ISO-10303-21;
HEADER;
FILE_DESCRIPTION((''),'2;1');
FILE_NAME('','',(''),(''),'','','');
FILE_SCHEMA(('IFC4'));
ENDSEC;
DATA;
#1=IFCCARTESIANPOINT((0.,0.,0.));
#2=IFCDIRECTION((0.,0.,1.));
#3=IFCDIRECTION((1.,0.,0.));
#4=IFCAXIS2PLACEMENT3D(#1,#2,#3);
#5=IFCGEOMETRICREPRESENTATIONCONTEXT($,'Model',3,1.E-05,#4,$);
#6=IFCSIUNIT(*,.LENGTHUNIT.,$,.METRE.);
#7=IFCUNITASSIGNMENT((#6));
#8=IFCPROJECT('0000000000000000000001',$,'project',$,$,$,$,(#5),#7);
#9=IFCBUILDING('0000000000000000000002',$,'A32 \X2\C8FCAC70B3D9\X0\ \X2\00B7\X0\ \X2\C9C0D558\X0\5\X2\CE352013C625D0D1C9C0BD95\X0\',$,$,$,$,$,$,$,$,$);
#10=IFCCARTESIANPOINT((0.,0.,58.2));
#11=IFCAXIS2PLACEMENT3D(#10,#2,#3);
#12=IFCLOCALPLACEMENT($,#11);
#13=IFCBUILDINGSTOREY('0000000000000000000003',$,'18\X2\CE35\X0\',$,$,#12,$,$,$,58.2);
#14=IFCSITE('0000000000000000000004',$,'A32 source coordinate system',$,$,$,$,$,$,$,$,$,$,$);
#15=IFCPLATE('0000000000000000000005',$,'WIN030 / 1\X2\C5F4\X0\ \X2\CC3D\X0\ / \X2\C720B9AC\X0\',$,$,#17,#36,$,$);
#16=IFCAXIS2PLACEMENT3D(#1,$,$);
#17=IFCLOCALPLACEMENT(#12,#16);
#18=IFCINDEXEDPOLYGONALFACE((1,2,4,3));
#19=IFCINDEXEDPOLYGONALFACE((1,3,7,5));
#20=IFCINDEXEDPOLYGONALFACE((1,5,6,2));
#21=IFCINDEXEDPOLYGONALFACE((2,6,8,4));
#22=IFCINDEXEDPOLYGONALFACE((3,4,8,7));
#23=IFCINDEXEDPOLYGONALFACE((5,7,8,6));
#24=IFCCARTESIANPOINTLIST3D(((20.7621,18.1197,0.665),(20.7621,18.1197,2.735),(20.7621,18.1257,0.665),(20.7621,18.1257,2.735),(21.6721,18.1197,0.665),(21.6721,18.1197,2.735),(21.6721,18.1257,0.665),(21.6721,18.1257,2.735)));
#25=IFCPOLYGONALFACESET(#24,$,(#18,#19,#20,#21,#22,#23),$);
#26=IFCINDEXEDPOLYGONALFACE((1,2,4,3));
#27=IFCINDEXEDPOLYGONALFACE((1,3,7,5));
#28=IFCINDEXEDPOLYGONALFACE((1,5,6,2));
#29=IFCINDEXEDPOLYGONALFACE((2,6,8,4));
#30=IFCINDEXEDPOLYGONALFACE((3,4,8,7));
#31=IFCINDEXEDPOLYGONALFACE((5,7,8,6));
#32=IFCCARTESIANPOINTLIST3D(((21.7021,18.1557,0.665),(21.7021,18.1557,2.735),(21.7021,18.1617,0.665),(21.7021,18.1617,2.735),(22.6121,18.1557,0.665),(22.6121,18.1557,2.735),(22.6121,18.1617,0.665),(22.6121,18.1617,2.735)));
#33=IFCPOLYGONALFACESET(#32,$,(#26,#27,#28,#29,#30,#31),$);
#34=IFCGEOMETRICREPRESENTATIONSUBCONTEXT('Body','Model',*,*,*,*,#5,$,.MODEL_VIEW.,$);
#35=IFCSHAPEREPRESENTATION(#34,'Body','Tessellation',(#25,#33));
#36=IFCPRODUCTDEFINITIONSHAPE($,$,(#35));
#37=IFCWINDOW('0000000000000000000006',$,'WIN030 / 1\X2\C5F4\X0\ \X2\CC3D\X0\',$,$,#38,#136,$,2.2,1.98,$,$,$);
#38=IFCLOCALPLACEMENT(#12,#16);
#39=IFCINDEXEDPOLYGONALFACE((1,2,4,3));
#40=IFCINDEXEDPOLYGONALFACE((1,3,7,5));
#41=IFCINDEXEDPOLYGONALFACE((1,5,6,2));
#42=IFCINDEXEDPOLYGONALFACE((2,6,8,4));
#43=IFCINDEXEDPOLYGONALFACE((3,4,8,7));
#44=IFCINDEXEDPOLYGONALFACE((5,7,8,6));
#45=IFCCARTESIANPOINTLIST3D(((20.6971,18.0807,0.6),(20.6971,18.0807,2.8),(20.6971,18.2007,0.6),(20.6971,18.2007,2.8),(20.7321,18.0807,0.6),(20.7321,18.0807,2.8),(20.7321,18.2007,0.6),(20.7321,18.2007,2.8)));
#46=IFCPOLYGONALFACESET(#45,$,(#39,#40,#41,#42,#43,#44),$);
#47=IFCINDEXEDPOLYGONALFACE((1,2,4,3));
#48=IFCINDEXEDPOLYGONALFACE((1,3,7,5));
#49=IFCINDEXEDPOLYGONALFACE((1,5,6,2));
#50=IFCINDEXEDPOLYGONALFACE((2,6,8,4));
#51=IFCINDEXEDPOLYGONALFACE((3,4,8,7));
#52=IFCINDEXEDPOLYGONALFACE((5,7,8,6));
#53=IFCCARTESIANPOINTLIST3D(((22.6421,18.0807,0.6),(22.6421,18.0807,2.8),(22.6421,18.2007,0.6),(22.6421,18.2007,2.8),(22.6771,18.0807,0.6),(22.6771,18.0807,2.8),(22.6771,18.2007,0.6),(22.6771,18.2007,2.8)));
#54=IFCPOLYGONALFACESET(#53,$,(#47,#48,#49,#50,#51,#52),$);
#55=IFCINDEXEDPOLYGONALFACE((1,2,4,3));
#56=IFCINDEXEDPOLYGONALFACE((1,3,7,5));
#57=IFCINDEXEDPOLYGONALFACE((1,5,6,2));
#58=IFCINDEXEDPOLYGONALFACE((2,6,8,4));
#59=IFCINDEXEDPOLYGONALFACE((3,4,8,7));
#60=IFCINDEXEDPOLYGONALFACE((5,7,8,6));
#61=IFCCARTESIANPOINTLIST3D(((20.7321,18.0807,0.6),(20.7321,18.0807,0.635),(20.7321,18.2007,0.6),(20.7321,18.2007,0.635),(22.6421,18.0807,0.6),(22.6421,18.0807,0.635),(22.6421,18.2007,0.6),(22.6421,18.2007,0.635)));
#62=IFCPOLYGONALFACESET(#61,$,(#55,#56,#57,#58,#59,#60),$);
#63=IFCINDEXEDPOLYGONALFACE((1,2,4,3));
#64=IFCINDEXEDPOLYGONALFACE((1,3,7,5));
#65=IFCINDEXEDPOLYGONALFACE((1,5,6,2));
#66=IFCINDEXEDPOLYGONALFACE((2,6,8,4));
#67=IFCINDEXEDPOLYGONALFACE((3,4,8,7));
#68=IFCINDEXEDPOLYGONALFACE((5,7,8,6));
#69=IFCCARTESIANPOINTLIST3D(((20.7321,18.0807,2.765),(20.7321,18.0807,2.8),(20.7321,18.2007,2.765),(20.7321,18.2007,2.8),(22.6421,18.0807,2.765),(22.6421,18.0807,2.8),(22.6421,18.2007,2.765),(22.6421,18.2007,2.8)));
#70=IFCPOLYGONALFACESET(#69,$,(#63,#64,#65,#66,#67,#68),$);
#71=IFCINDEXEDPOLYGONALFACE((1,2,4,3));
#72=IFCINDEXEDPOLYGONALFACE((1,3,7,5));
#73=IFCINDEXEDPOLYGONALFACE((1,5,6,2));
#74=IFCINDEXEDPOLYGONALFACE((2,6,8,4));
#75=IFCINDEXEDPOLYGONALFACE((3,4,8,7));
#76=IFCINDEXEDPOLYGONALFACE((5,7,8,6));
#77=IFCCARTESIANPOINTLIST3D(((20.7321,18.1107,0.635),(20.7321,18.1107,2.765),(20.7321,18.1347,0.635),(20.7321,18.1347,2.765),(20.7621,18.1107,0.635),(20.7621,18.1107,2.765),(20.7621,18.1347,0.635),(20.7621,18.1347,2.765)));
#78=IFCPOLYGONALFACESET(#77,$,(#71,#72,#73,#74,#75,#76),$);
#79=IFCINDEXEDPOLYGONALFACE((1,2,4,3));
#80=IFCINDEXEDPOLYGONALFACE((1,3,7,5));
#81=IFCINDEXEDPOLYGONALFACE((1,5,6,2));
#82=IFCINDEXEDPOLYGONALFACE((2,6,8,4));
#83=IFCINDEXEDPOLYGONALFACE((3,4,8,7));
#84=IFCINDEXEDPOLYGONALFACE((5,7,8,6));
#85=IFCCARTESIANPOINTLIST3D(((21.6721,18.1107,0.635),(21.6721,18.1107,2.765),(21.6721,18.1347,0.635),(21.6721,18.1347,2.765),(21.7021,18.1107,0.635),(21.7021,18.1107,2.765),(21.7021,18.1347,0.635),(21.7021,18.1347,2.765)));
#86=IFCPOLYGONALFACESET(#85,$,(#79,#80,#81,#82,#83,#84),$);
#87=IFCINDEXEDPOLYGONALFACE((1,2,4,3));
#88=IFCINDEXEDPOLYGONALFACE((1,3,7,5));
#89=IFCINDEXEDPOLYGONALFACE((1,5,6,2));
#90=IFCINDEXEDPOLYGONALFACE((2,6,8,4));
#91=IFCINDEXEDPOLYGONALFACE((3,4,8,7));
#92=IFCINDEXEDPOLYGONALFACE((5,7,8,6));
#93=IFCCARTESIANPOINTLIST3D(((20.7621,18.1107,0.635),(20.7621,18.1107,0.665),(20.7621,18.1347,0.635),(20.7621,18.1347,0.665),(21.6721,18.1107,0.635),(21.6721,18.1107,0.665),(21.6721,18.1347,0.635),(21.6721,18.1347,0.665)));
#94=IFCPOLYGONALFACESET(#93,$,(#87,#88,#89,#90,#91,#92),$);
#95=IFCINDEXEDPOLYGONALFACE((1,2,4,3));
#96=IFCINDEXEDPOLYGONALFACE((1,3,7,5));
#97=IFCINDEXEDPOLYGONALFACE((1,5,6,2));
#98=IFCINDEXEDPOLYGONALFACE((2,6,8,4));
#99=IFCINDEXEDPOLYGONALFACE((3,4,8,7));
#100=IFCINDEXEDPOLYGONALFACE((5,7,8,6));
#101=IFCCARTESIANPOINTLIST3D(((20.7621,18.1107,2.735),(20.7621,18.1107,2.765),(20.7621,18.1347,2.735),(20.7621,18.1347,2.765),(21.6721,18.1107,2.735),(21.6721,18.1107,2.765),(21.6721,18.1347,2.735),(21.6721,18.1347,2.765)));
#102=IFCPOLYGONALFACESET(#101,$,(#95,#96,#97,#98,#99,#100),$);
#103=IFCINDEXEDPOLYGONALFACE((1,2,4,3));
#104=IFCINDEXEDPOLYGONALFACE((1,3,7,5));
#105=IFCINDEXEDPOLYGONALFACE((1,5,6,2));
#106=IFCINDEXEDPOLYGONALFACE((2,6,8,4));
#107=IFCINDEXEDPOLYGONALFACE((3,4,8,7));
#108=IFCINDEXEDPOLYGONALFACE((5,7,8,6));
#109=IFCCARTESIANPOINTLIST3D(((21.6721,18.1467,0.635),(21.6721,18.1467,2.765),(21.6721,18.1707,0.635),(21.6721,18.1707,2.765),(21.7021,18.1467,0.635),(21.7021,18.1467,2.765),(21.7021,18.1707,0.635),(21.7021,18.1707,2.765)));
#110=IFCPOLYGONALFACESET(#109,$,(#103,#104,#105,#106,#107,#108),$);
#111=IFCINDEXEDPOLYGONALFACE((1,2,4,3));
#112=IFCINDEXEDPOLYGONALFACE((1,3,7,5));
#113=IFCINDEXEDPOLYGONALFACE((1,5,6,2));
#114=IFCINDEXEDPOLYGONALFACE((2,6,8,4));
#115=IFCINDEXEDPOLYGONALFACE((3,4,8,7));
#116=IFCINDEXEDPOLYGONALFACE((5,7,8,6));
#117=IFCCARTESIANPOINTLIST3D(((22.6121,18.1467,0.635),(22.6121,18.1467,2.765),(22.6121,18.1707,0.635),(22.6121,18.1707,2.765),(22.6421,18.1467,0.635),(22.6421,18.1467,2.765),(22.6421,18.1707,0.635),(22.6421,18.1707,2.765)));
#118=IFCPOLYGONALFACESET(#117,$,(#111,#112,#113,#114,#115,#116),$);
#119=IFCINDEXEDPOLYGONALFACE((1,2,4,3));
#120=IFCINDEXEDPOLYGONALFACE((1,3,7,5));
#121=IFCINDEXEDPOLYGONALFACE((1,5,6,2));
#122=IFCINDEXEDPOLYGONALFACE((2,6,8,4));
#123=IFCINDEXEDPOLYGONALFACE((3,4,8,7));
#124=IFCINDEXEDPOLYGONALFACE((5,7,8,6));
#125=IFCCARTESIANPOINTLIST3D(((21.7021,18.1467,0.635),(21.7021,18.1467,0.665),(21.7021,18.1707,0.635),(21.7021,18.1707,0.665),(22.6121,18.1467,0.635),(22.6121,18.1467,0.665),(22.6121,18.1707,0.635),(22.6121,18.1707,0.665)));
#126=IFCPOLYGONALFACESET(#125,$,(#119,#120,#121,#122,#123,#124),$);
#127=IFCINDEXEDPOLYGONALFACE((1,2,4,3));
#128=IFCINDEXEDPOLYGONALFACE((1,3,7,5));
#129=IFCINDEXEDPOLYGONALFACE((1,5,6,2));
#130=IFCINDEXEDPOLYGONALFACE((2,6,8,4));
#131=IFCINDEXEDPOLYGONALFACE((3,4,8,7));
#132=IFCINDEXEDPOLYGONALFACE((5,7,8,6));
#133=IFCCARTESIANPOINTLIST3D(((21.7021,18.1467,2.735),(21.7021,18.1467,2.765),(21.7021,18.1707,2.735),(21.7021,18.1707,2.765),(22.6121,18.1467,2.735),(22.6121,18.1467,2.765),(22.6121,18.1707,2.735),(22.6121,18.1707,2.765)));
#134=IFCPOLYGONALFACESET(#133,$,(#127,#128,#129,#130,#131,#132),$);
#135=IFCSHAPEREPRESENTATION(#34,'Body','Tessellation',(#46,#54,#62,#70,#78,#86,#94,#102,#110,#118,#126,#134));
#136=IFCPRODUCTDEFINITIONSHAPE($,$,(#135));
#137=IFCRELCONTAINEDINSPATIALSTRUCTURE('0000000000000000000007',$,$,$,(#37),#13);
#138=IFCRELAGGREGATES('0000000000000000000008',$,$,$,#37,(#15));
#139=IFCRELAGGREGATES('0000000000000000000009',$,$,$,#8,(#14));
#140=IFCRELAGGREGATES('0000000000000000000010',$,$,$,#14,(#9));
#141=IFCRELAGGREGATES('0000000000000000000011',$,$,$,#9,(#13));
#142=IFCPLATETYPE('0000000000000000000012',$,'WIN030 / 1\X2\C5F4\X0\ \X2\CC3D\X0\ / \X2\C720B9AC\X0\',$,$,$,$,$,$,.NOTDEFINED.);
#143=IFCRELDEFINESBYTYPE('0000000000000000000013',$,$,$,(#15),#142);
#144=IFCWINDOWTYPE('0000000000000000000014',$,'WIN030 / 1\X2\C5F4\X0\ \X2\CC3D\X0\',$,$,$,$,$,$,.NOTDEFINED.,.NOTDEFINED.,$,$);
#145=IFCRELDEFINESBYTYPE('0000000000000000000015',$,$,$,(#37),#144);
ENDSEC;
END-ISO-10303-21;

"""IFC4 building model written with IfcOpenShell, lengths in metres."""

from ifc_helpers import new_model, si_unit, frame, origin, origin_with_axes, place, context, subcontext, project, spatial, polyline, outline, extrude, source, transform, mapped, type_object, type_shapes, element, aggregate, save


model = new_model("IFC4")

# Units and contexts
model_context = context("Model", 3, precision=1e-05, world=origin_with_axes())
body_context = subcontext(model_context, "Body", "Model", "MODEL_VIEW")
ifc_project = project(units=[si_unit("LENGTHUNIT", "METRE")], contexts=[model_context])

# Plate
storey_placement = place(None, frame((0.0, 0.0, 58.2), z_axis=(0.0, 0.0, 1.0), x_axis=(1.0, 0.0, 0.0)))
plate_type_1 = type_object("IfcPlateType", Name="WIN030 / 1열 창 / 유리", PredefinedType="NOTDEFINED")
shared_shape_1 = source(origin(), body_context, "Body", "SweptSolid", [
    extrude(outline(polyline([(20.7621, 18.1197), (20.7621, 18.1257), (21.6721, 18.1257), (21.6721, 18.1197), (20.7621, 18.1197)])), frame((0.0, 0.0, 0.665)), (0.0, 0.0, 1.0), 2.07),
    extrude(outline(polyline([(21.7021, 18.1557), (21.7021, 18.1617), (22.6121, 18.1617), (22.6121, 18.1557), (21.7021, 18.1557)])), frame((0.0, 0.0, 0.665)), (0.0, 0.0, 1.0), 2.07),
])
type_shapes(plate_type_1, [shared_shape_1])
window_1_placement = place(storey_placement, origin_with_axes())
plate_1_placement = place(window_1_placement, origin_with_axes())
plate_1 = element("IfcPlate", 1, at=plate_1_placement, type_object=plate_type_1, Name="WIN030 / 1열 창 / 유리", context=body_context, shape_type="MappedRepresentation", body=[
    mapped(shared_shape_1, transform((0.0, 0.0, 0.0), scale=1.0)),
])

# Site, building, storey
site = spatial("IfcSite", under=ifc_project, Name="A32 source coordinate system")
building = spatial("IfcBuilding", under=site, Name="A32 주거동 · 지하5층–옥탑지붕")
storey = spatial("IfcBuildingStorey", under=building, at=storey_placement, Name="18층", Elevation=58.2)

# Window
window_type_1 = type_object("IfcWindowType", Name="WIN030 / 1열 창", PartitioningType="NOTDEFINED", PredefinedType="NOTDEFINED")
shared_shape_2 = source(origin(), body_context, "Body", "SweptSolid", [
    extrude(outline(polyline([(20.6971, 18.0807), (20.6971, 18.2007), (20.7321, 18.2007), (20.7321, 18.0807), (20.6971, 18.0807)])), frame((0.0, 0.0, 0.6)), (0.0, 0.0, 1.0), 2.2),
    extrude(outline(polyline([(22.6421, 18.0807), (22.6421, 18.2007), (22.6771, 18.2007), (22.6771, 18.0807), (22.6421, 18.0807)])), frame((0.0, 0.0, 0.6)), (0.0, 0.0, 1.0), 2.2),
    extrude(outline(polyline([(20.7321, 18.0807), (20.7321, 18.2007), (22.6421, 18.2007), (22.6421, 18.0807), (20.7321, 18.0807)])), frame((0.0, 0.0, 0.6)), (0.0, 0.0, 1.0), 0.035),
    extrude(outline(polyline([(20.7321, 18.0807), (20.7321, 18.2007), (22.6421, 18.2007), (22.6421, 18.0807), (20.7321, 18.0807)])), frame((0.0, 0.0, 2.765)), (0.0, 0.0, 1.0), 0.035),
    extrude(outline(polyline([(20.7321, 18.1107), (20.7321, 18.1347), (20.7621, 18.1347), (20.7621, 18.1107), (20.7321, 18.1107)])), frame((0.0, 0.0, 0.635)), (0.0, 0.0, 1.0), 2.13),
    extrude(outline(polyline([(21.6721, 18.1107), (21.6721, 18.1347), (21.7021, 18.1347), (21.7021, 18.1107), (21.6721, 18.1107)])), frame((0.0, 0.0, 0.635)), (0.0, 0.0, 1.0), 2.13),
    extrude(outline(polyline([(20.7621, 18.1107), (20.7621, 18.1347), (21.6721, 18.1347), (21.6721, 18.1107), (20.7621, 18.1107)])), frame((0.0, 0.0, 0.635)), (0.0, 0.0, 1.0), 0.03),
    extrude(outline(polyline([(20.7621, 18.1107), (20.7621, 18.1347), (21.6721, 18.1347), (21.6721, 18.1107), (20.7621, 18.1107)])), frame((0.0, 0.0, 2.735)), (0.0, 0.0, 1.0), 0.03),
    extrude(outline(polyline([(21.6721, 18.1467), (21.6721, 18.1707), (21.7021, 18.1707), (21.7021, 18.1467), (21.6721, 18.1467)])), frame((0.0, 0.0, 0.635)), (0.0, 0.0, 1.0), 2.13),
    extrude(outline(polyline([(22.6121, 18.1467), (22.6121, 18.1707), (22.6421, 18.1707), (22.6421, 18.1467), (22.6121, 18.1467)])), frame((0.0, 0.0, 0.635)), (0.0, 0.0, 1.0), 2.13),
    extrude(outline(polyline([(21.7021, 18.1467), (21.7021, 18.1707), (22.6121, 18.1707), (22.6121, 18.1467), (21.7021, 18.1467)])), frame((0.0, 0.0, 0.635)), (0.0, 0.0, 1.0), 0.03),
    extrude(outline(polyline([(21.7021, 18.1467), (21.7021, 18.1707), (22.6121, 18.1707), (22.6121, 18.1467), (21.7021, 18.1467)])), frame((0.0, 0.0, 2.735)), (0.0, 0.0, 1.0), 0.03),
])
type_shapes(window_type_1, [shared_shape_2])
window_1 = element("IfcWindow", 2, at=window_1_placement, inside=storey, type_object=window_type_1, Name="WIN030 / 1열 창", OverallHeight=2.2, OverallWidth=1.98, context=body_context, shape_type="MappedRepresentation", body=[
    mapped(shared_shape_2, transform((0.0, 0.0, 0.0), scale=1.0)),
])
aggregate(window_1, [plate_1])

save(model, "model.ifc")
